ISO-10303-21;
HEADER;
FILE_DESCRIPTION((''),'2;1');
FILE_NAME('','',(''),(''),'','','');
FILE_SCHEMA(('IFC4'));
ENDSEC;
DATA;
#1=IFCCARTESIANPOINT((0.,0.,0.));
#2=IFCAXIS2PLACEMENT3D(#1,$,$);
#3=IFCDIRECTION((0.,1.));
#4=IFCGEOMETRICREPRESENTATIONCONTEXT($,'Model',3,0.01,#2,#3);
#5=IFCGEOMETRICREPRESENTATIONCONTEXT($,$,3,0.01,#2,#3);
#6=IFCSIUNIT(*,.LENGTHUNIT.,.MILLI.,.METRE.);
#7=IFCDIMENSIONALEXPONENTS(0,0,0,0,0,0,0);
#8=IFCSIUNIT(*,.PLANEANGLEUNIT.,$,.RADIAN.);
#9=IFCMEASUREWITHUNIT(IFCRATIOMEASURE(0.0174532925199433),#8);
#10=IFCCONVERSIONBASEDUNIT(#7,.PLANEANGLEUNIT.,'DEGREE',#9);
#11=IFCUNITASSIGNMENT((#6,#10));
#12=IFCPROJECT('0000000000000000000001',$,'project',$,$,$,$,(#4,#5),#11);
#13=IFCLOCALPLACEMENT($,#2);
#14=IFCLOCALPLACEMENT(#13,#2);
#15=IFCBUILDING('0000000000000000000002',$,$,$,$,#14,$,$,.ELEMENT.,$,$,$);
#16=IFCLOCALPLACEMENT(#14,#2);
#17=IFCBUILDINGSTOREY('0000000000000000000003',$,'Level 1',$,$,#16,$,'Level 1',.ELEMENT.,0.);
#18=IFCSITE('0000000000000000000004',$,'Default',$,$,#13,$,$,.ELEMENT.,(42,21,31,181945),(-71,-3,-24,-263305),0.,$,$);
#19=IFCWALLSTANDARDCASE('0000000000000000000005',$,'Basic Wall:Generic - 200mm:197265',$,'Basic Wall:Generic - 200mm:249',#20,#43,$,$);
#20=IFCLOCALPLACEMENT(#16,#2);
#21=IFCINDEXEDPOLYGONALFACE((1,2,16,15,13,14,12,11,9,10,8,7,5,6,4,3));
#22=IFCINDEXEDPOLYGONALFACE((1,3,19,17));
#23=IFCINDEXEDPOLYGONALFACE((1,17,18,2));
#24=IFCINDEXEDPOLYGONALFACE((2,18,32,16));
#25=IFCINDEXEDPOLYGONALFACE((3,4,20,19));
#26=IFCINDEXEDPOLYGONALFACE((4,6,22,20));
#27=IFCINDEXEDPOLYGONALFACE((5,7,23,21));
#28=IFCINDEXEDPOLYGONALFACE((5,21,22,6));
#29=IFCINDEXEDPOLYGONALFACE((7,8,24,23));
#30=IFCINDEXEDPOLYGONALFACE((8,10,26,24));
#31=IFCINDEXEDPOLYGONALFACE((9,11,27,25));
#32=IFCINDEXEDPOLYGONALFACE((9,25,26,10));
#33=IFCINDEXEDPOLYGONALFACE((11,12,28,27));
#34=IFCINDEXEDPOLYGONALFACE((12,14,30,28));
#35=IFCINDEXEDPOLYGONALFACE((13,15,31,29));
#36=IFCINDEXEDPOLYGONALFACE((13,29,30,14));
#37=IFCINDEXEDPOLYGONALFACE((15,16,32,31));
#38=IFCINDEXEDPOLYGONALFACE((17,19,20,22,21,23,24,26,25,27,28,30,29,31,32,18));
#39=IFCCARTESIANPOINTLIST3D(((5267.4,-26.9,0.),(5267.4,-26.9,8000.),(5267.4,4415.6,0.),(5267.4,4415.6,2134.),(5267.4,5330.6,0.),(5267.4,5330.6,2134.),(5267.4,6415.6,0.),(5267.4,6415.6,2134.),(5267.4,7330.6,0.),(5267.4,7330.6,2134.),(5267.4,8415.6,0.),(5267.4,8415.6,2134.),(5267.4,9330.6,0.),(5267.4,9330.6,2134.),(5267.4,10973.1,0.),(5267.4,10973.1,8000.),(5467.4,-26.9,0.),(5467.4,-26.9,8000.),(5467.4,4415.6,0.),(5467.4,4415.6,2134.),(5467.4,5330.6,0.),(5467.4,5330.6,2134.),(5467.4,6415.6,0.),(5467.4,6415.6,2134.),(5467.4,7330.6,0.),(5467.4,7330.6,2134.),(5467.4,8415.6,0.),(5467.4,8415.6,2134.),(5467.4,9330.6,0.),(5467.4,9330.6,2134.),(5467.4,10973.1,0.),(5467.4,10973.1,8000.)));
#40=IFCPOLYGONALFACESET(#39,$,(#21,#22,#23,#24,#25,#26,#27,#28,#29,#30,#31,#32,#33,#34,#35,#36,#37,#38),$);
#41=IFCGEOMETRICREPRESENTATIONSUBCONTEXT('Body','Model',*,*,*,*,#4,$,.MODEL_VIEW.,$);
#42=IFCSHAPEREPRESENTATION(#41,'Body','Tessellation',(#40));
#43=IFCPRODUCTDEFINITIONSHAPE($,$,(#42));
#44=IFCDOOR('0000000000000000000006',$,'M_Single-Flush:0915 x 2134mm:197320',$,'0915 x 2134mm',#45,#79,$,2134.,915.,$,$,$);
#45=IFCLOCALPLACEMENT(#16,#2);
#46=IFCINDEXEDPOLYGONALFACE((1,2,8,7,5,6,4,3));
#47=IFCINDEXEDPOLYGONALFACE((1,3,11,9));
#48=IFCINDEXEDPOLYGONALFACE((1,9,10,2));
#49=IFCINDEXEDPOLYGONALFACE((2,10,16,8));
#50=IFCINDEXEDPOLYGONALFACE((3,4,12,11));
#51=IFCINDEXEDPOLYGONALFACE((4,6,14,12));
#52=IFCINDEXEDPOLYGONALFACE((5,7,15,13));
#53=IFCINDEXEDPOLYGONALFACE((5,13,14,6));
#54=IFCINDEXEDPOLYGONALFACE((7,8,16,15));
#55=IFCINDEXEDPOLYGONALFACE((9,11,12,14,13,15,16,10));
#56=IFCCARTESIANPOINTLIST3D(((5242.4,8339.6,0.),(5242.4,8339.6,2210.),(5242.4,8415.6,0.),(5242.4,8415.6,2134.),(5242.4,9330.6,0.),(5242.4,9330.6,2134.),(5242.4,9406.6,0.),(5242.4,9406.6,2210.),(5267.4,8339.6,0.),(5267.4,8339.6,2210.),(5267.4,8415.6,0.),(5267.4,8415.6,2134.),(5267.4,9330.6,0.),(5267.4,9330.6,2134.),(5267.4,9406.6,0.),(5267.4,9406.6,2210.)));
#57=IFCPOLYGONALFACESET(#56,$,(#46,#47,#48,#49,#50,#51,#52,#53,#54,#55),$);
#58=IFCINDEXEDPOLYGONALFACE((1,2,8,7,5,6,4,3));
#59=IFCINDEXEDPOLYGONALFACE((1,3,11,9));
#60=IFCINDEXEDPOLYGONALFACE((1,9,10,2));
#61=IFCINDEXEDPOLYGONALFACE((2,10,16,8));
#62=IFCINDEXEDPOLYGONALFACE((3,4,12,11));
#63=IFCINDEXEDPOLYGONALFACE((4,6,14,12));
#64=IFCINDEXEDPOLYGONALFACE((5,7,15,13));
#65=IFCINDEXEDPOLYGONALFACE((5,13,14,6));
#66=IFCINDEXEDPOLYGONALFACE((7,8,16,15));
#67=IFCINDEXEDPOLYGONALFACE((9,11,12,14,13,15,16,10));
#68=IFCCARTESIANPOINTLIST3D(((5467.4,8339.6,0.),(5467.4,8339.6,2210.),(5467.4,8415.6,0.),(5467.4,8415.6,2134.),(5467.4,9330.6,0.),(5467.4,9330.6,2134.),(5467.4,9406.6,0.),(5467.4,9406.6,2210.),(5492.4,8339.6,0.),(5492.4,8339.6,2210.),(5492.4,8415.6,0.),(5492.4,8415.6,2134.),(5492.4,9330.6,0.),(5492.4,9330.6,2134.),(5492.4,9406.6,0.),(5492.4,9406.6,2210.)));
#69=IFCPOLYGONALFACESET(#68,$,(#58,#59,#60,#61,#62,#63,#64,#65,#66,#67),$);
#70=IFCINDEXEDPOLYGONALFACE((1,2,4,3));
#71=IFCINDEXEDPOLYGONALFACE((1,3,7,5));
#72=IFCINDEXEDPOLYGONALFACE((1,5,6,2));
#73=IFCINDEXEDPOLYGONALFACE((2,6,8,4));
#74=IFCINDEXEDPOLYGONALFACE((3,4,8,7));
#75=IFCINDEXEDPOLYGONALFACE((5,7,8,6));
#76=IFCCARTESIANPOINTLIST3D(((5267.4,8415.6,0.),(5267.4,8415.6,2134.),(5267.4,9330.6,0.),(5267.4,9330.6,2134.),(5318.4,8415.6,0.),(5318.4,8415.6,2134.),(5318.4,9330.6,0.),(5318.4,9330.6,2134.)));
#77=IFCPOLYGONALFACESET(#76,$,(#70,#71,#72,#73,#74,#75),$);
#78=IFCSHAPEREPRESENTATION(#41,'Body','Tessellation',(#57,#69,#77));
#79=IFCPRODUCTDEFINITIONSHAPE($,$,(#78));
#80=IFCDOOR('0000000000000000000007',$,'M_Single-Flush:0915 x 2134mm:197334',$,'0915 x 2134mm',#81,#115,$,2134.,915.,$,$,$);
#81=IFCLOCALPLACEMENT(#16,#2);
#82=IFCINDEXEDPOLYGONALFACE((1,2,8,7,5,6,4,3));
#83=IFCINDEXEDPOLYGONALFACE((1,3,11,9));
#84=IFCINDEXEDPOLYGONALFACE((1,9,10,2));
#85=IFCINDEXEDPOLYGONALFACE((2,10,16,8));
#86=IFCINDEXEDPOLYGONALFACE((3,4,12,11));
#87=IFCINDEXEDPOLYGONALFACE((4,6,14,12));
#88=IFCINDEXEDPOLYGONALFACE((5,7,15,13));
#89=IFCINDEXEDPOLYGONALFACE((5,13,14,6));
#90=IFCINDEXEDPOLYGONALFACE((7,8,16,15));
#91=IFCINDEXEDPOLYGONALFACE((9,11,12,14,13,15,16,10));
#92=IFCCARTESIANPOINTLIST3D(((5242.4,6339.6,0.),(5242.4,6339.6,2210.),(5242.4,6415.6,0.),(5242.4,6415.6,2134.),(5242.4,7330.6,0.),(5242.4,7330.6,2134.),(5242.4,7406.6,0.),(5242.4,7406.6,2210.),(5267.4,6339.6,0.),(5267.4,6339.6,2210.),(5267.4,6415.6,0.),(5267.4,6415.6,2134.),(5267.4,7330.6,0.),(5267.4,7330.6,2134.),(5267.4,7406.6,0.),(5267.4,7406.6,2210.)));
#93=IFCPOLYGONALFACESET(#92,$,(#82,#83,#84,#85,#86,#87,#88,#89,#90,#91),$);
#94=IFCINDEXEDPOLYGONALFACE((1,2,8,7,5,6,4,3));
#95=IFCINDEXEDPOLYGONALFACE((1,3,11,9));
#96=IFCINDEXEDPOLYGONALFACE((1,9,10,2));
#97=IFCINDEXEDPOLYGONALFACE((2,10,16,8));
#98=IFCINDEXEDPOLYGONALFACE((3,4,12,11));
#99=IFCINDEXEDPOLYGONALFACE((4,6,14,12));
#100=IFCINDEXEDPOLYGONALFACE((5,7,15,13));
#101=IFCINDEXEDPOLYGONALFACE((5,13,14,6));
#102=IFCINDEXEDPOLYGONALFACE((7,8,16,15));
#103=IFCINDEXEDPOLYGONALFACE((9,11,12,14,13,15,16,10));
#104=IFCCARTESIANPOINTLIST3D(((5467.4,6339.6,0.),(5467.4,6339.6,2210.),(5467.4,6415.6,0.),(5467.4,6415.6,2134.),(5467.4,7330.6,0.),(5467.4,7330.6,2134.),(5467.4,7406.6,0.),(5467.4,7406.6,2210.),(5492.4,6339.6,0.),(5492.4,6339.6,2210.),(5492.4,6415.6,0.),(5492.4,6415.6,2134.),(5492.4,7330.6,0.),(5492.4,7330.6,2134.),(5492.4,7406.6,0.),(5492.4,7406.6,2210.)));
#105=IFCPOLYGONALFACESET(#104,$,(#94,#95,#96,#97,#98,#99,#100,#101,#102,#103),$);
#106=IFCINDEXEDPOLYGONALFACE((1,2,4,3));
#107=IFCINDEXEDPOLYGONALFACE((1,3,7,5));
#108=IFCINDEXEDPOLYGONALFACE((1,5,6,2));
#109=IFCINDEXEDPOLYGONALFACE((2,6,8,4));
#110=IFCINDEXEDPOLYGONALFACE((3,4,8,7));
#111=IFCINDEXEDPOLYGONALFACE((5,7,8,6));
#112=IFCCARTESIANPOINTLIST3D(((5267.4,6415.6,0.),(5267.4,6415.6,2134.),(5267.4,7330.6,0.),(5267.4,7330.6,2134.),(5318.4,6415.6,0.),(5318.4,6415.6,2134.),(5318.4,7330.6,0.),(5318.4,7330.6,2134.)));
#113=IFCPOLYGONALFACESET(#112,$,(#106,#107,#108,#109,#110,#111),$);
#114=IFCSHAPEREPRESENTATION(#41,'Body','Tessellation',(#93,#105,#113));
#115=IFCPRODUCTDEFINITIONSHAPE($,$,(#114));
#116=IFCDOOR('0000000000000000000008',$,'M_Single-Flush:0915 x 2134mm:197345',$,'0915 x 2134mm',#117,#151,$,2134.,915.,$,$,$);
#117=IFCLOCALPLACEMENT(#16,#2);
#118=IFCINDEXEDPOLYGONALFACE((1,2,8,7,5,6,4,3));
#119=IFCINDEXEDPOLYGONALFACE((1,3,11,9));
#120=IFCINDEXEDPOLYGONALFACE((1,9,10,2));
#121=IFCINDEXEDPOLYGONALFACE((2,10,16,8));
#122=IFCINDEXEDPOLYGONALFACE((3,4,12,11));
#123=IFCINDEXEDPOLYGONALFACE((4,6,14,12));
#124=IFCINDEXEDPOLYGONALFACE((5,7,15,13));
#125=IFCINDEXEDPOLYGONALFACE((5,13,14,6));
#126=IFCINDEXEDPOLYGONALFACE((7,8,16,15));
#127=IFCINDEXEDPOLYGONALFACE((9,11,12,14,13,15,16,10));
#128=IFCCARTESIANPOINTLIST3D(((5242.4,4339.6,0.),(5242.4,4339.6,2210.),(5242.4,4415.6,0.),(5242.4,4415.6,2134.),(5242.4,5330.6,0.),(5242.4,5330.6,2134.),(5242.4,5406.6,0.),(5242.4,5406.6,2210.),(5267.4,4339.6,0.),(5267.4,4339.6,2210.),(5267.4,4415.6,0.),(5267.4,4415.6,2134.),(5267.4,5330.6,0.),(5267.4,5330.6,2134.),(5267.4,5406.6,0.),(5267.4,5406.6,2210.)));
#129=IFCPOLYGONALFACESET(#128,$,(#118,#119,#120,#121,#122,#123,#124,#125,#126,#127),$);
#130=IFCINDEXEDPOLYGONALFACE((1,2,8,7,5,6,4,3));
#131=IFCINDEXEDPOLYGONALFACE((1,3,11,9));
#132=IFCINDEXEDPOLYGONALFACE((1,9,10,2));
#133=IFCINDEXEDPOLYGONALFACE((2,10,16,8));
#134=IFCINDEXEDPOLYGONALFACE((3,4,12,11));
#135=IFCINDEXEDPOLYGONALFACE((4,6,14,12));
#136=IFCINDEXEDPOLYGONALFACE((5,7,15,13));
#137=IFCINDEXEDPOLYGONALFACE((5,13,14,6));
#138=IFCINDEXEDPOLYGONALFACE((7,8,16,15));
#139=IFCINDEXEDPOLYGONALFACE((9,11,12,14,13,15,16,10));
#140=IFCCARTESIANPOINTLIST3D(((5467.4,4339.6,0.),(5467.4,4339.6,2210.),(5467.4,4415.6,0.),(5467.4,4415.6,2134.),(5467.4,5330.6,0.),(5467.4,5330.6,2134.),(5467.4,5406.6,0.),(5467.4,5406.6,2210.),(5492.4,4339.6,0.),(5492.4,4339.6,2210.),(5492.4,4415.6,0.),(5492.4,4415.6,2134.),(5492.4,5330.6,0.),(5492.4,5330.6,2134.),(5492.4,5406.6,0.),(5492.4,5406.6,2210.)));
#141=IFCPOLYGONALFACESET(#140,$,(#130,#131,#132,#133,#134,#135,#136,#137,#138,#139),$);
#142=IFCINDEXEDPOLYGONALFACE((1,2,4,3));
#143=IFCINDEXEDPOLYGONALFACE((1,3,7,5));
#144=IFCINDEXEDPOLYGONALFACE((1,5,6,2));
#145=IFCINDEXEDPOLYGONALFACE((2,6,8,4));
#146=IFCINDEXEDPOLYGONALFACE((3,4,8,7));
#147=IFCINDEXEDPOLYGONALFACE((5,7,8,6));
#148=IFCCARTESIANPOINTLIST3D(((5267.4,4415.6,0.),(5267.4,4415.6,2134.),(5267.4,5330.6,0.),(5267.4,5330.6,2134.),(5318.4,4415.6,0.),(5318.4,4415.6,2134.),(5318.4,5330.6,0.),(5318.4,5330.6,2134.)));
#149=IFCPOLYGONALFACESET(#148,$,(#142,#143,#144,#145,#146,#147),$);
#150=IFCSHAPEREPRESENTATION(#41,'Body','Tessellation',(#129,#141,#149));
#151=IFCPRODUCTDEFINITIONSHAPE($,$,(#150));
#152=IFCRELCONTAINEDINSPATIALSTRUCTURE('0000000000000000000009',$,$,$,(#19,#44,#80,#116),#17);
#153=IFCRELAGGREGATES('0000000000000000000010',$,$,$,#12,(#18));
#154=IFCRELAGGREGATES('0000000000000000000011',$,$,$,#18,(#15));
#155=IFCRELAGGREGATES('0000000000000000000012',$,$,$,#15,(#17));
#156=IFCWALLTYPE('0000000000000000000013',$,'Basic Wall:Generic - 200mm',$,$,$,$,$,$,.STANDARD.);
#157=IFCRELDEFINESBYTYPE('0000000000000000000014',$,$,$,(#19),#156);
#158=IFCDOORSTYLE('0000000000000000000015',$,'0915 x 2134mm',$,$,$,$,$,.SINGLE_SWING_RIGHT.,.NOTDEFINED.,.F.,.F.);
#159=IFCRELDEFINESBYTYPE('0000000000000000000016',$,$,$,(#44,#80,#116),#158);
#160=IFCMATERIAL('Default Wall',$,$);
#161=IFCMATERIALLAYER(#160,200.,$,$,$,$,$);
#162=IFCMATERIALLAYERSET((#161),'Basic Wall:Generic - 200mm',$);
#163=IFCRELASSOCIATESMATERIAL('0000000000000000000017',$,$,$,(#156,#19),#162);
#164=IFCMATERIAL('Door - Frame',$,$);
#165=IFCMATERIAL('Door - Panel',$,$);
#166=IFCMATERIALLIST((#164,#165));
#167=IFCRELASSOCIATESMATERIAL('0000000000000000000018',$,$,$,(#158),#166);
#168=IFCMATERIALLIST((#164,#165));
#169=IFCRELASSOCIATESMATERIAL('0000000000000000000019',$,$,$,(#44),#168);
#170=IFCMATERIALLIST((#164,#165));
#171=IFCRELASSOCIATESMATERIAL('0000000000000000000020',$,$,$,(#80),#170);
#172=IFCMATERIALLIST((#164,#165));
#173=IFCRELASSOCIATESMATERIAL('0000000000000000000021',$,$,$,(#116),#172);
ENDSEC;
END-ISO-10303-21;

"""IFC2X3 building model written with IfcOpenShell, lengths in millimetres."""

from ifc_helpers import new_model, entity, si_unit, converted_unit, direction, frame, frame_2d, origin, place, context, subcontext, project, spatial, polyline, rectangle, outline, extrude, source, transform, mapped, material, material_list, layer, layer_set, layer_usage, type_object, type_shapes, element, fill, save


model = new_model("IFC2X3")

# Units and contexts
model_context = context("Model", 3, precision=0.01, world=origin(), true_north=direction((0.0, 1.0)))
context_of_model = context(None, 3, precision=0.01, world=origin(), true_north=direction((0.0, 1.0)))
body_context = subcontext(model_context, "Body", "Model", "MODEL_VIEW")
ifc_project = project(units=[si_unit("LENGTHUNIT", "METRE", prefix="MILLI"), converted_unit("PLANEANGLEUNIT", "DEGREE", entity("IfcRatioMeasure", 0.0174532925199433), si_unit("PLANEANGLEUNIT", "RADIAN"), dimensions=[0, 0, 0, 0, 0, 0, 0])], contexts=[model_context, context_of_model])

# Site, building, storey
site_placement = place(None, origin())
site = spatial("IfcSite", under=ifc_project, at=site_placement, Name="Default", CompositionType="ELEMENT", RefLatitude=(42, 21, 31, 181945), RefLongitude=(-71, -3, -24, -263305), RefElevation=0.0)
building_placement = place(site_placement, origin())
building = spatial("IfcBuilding", under=site, at=building_placement, CompositionType="ELEMENT")
storey_placement = place(building_placement, origin())
storey = spatial("IfcBuildingStorey", under=building, at=storey_placement, Name="Level 1", LongName="Level 1", CompositionType="ELEMENT", Elevation=0.0)

# Shared definitions
ifc_material_1 = material(Name="Default Wall")
ifc_layer = layer(ifc_material_1, 200.0)
ifc_layer_set = layer_set([ifc_layer], Name="Basic Wall:Generic - 200mm")
wall_type = type_object("IfcWallType", Name="Basic Wall:Generic - 200mm", PredefinedType="STANDARD", material=ifc_layer_set)
ifc_material_2 = material(Name="Door - Frame")
ifc_material_3 = material(Name="Door - Panel")
ifc_material_list_1 = material_list([ifc_material_2, ifc_material_3])
door_style = type_object("IfcDoorStyle", Name="0915 x 2134mm", ConstructionType="NOTDEFINED", OperationType="SINGLE_SWING_RIGHT", ParameterTakesPrecedence=False, Sizeable=False, material=ifc_material_list_1)
shared_shape = source(origin(), body_context, "Body", "SweptSolid", [
    extrude(outline(polyline([(-533.5, -1124.0), (533.5, -1124.0), (533.5, 1086.0), (457.5, 1086.0), (457.5, -1048.0), (-457.5, -1048.0), (-457.5, 1086.0), (-533.5, 1086.0), (-533.5, -1124.0)])), frame((457.5, 200.0, 1086.0), z_axis=(0.0, 1.0, 0.0), x_axis=(1.0, 0.0, 0.0)), (0.0, 0.0, 1.0), 25.0),
    extrude(outline(polyline([(-1124.0, -533.5), (1086.0, -533.5), (1086.0, -457.5), (-1048.0, -457.5), (-1048.0, 457.5), (1086.0, 457.5), (1086.0, 533.5), (-1124.0, 533.5), (-1124.0, -533.5)])), frame((457.5, -25.0, 1086.0), z_axis=(0.0, 1.0, 0.0), x_axis=(0.0, 0.0, -1.0)), (0.0, 0.0, 1.0), 25.0),
    extrude(rectangle(XDim=51.0, YDim=915.0, at=frame_2d((0.0, 0.0), x_axis=(1.0, 0.0))), frame((457.5, 174.5, 0.0), z_axis=(0.0, 0.0, 1.0), x_axis=(0.0, 1.0, 0.0)), (0.0, 0.0, 1.0), 2134.0),
])
type_shapes(door_style, [shared_shape])

# Wall, openings, doors
ifc_layer_usage_1 = layer_usage(ifc_layer_set, "AXIS2", "NEGATIVE", 100.0)
wall_1_placement = place(storey_placement, frame((5367.4, 10973.1, 0.0), z_axis=(0.0, 0.0, 1.0), x_axis=(0.0, -1.0, 0.0)))
wall_1 = element("IfcWallStandardCase", 1, at=wall_1_placement, inside=storey, type_object=wall_type, material=ifc_layer_usage_1, Name="Basic Wall:Generic - 200mm:197265", ObjectType="Basic Wall:Generic - 200mm:249", context=body_context, shape_type="SweptSolid", body=[
    extrude(rectangle(XDim=11000.0, YDim=200.0, at=frame_2d((5500.0, 0.0), x_axis=(-1.0, 0.0))), origin(), (0.0, 0.0, 1.0), 8000.0),
])
opening_1_placement = place(wall_1_placement, frame((2557.5, 100.0, 0.0)))
opening_1 = element("IfcOpeningElement", 2, at=opening_1_placement, cuts=wall_1, ObjectType="Opening", context=body_context, shape_type="SweptSolid", body=[
    extrude(rectangle(XDim=915.0, YDim=2134.0, at=frame_2d((1067.0, 457.5), x_axis=(0.0, 1.0))), frame((0.0, 0.0, 0.0), z_axis=(0.0, -1.0, 0.0), x_axis=(0.0, 0.0, 1.0)), (0.0, 0.0, 1.0), 200.0),
])
opening_2_placement = place(wall_1_placement, frame((4557.5, 100.0, 0.0)))
opening_2 = element("IfcOpeningElement", 3, at=opening_2_placement, cuts=wall_1, ObjectType="Opening", context=body_context, shape_type="SweptSolid", body=[
    extrude(rectangle(XDim=915.0, YDim=2134.0, at=frame_2d((1067.0, 457.5), x_axis=(0.0, 1.0))), frame((0.0, 0.0, 0.0), z_axis=(0.0, -1.0, 0.0), x_axis=(0.0, 0.0, 1.0)), (0.0, 0.0, 1.0), 200.0),
])
opening_3_placement = place(wall_1_placement, frame((6557.5, 100.0, 0.0)))
opening_3 = element("IfcOpeningElement", 4, at=opening_3_placement, cuts=wall_1, ObjectType="Opening", context=body_context, shape_type="SweptSolid", body=[
    extrude(rectangle(XDim=915.0, YDim=2134.0, at=frame_2d((1067.0, 457.5), x_axis=(0.0, 1.0))), frame((0.0, 0.0, 0.0), z_axis=(0.0, -1.0, 0.0), x_axis=(0.0, 0.0, 1.0)), (0.0, 0.0, 1.0), 200.0),
])
ifc_material_list_2 = material_list([ifc_material_2, ifc_material_3])
door_1_placement = place(opening_1_placement, frame((0.0, 0.0, 0.0), z_axis=(0.0, 0.0, 1.0), x_axis=(-1.0, 0.0, 0.0)))
door_1 = element("IfcDoor", 5, at=door_1_placement, inside=storey, type_object=door_style, material=ifc_material_list_2, Name="M_Single-Flush:0915 x 2134mm:197320", ObjectType="0915 x 2134mm", OverallHeight=2134.0, OverallWidth=915.0, context=body_context, shape_type="MappedRepresentation", body=[
    mapped(shared_shape, transform((0.0, 0.0, 0.0), scale=1.0)),
])
fill(opening_1, door_1)
ifc_material_list_3 = material_list([ifc_material_2, ifc_material_3])
door_2_placement = place(opening_2_placement, frame((0.0, 0.0, 0.0), z_axis=(0.0, 0.0, 1.0), x_axis=(-1.0, 0.0, 0.0)))
door_2 = element("IfcDoor", 6, at=door_2_placement, inside=storey, type_object=door_style, material=ifc_material_list_3, Name="M_Single-Flush:0915 x 2134mm:197334", ObjectType="0915 x 2134mm", OverallHeight=2134.0, OverallWidth=915.0, context=body_context, shape_type="MappedRepresentation", body=[
    mapped(shared_shape, transform((0.0, 0.0, 0.0), scale=1.0)),
])
fill(opening_2, door_2)
ifc_material_list_4 = material_list([ifc_material_2, ifc_material_3])
door_3_placement = place(opening_3_placement, frame((0.0, 0.0, 0.0), z_axis=(0.0, 0.0, 1.0), x_axis=(-1.0, 0.0, 0.0)))
door_3 = element("IfcDoor", 7, at=door_3_placement, inside=storey, type_object=door_style, material=ifc_material_list_4, Name="M_Single-Flush:0915 x 2134mm:197345", ObjectType="0915 x 2134mm", OverallHeight=2134.0, OverallWidth=915.0, context=body_context, shape_type="MappedRepresentation", body=[
    mapped(shared_shape, transform((0.0, 0.0, 0.0), scale=1.0)),
])
fill(opening_3, door_3)

save(model, "model.ifc")
